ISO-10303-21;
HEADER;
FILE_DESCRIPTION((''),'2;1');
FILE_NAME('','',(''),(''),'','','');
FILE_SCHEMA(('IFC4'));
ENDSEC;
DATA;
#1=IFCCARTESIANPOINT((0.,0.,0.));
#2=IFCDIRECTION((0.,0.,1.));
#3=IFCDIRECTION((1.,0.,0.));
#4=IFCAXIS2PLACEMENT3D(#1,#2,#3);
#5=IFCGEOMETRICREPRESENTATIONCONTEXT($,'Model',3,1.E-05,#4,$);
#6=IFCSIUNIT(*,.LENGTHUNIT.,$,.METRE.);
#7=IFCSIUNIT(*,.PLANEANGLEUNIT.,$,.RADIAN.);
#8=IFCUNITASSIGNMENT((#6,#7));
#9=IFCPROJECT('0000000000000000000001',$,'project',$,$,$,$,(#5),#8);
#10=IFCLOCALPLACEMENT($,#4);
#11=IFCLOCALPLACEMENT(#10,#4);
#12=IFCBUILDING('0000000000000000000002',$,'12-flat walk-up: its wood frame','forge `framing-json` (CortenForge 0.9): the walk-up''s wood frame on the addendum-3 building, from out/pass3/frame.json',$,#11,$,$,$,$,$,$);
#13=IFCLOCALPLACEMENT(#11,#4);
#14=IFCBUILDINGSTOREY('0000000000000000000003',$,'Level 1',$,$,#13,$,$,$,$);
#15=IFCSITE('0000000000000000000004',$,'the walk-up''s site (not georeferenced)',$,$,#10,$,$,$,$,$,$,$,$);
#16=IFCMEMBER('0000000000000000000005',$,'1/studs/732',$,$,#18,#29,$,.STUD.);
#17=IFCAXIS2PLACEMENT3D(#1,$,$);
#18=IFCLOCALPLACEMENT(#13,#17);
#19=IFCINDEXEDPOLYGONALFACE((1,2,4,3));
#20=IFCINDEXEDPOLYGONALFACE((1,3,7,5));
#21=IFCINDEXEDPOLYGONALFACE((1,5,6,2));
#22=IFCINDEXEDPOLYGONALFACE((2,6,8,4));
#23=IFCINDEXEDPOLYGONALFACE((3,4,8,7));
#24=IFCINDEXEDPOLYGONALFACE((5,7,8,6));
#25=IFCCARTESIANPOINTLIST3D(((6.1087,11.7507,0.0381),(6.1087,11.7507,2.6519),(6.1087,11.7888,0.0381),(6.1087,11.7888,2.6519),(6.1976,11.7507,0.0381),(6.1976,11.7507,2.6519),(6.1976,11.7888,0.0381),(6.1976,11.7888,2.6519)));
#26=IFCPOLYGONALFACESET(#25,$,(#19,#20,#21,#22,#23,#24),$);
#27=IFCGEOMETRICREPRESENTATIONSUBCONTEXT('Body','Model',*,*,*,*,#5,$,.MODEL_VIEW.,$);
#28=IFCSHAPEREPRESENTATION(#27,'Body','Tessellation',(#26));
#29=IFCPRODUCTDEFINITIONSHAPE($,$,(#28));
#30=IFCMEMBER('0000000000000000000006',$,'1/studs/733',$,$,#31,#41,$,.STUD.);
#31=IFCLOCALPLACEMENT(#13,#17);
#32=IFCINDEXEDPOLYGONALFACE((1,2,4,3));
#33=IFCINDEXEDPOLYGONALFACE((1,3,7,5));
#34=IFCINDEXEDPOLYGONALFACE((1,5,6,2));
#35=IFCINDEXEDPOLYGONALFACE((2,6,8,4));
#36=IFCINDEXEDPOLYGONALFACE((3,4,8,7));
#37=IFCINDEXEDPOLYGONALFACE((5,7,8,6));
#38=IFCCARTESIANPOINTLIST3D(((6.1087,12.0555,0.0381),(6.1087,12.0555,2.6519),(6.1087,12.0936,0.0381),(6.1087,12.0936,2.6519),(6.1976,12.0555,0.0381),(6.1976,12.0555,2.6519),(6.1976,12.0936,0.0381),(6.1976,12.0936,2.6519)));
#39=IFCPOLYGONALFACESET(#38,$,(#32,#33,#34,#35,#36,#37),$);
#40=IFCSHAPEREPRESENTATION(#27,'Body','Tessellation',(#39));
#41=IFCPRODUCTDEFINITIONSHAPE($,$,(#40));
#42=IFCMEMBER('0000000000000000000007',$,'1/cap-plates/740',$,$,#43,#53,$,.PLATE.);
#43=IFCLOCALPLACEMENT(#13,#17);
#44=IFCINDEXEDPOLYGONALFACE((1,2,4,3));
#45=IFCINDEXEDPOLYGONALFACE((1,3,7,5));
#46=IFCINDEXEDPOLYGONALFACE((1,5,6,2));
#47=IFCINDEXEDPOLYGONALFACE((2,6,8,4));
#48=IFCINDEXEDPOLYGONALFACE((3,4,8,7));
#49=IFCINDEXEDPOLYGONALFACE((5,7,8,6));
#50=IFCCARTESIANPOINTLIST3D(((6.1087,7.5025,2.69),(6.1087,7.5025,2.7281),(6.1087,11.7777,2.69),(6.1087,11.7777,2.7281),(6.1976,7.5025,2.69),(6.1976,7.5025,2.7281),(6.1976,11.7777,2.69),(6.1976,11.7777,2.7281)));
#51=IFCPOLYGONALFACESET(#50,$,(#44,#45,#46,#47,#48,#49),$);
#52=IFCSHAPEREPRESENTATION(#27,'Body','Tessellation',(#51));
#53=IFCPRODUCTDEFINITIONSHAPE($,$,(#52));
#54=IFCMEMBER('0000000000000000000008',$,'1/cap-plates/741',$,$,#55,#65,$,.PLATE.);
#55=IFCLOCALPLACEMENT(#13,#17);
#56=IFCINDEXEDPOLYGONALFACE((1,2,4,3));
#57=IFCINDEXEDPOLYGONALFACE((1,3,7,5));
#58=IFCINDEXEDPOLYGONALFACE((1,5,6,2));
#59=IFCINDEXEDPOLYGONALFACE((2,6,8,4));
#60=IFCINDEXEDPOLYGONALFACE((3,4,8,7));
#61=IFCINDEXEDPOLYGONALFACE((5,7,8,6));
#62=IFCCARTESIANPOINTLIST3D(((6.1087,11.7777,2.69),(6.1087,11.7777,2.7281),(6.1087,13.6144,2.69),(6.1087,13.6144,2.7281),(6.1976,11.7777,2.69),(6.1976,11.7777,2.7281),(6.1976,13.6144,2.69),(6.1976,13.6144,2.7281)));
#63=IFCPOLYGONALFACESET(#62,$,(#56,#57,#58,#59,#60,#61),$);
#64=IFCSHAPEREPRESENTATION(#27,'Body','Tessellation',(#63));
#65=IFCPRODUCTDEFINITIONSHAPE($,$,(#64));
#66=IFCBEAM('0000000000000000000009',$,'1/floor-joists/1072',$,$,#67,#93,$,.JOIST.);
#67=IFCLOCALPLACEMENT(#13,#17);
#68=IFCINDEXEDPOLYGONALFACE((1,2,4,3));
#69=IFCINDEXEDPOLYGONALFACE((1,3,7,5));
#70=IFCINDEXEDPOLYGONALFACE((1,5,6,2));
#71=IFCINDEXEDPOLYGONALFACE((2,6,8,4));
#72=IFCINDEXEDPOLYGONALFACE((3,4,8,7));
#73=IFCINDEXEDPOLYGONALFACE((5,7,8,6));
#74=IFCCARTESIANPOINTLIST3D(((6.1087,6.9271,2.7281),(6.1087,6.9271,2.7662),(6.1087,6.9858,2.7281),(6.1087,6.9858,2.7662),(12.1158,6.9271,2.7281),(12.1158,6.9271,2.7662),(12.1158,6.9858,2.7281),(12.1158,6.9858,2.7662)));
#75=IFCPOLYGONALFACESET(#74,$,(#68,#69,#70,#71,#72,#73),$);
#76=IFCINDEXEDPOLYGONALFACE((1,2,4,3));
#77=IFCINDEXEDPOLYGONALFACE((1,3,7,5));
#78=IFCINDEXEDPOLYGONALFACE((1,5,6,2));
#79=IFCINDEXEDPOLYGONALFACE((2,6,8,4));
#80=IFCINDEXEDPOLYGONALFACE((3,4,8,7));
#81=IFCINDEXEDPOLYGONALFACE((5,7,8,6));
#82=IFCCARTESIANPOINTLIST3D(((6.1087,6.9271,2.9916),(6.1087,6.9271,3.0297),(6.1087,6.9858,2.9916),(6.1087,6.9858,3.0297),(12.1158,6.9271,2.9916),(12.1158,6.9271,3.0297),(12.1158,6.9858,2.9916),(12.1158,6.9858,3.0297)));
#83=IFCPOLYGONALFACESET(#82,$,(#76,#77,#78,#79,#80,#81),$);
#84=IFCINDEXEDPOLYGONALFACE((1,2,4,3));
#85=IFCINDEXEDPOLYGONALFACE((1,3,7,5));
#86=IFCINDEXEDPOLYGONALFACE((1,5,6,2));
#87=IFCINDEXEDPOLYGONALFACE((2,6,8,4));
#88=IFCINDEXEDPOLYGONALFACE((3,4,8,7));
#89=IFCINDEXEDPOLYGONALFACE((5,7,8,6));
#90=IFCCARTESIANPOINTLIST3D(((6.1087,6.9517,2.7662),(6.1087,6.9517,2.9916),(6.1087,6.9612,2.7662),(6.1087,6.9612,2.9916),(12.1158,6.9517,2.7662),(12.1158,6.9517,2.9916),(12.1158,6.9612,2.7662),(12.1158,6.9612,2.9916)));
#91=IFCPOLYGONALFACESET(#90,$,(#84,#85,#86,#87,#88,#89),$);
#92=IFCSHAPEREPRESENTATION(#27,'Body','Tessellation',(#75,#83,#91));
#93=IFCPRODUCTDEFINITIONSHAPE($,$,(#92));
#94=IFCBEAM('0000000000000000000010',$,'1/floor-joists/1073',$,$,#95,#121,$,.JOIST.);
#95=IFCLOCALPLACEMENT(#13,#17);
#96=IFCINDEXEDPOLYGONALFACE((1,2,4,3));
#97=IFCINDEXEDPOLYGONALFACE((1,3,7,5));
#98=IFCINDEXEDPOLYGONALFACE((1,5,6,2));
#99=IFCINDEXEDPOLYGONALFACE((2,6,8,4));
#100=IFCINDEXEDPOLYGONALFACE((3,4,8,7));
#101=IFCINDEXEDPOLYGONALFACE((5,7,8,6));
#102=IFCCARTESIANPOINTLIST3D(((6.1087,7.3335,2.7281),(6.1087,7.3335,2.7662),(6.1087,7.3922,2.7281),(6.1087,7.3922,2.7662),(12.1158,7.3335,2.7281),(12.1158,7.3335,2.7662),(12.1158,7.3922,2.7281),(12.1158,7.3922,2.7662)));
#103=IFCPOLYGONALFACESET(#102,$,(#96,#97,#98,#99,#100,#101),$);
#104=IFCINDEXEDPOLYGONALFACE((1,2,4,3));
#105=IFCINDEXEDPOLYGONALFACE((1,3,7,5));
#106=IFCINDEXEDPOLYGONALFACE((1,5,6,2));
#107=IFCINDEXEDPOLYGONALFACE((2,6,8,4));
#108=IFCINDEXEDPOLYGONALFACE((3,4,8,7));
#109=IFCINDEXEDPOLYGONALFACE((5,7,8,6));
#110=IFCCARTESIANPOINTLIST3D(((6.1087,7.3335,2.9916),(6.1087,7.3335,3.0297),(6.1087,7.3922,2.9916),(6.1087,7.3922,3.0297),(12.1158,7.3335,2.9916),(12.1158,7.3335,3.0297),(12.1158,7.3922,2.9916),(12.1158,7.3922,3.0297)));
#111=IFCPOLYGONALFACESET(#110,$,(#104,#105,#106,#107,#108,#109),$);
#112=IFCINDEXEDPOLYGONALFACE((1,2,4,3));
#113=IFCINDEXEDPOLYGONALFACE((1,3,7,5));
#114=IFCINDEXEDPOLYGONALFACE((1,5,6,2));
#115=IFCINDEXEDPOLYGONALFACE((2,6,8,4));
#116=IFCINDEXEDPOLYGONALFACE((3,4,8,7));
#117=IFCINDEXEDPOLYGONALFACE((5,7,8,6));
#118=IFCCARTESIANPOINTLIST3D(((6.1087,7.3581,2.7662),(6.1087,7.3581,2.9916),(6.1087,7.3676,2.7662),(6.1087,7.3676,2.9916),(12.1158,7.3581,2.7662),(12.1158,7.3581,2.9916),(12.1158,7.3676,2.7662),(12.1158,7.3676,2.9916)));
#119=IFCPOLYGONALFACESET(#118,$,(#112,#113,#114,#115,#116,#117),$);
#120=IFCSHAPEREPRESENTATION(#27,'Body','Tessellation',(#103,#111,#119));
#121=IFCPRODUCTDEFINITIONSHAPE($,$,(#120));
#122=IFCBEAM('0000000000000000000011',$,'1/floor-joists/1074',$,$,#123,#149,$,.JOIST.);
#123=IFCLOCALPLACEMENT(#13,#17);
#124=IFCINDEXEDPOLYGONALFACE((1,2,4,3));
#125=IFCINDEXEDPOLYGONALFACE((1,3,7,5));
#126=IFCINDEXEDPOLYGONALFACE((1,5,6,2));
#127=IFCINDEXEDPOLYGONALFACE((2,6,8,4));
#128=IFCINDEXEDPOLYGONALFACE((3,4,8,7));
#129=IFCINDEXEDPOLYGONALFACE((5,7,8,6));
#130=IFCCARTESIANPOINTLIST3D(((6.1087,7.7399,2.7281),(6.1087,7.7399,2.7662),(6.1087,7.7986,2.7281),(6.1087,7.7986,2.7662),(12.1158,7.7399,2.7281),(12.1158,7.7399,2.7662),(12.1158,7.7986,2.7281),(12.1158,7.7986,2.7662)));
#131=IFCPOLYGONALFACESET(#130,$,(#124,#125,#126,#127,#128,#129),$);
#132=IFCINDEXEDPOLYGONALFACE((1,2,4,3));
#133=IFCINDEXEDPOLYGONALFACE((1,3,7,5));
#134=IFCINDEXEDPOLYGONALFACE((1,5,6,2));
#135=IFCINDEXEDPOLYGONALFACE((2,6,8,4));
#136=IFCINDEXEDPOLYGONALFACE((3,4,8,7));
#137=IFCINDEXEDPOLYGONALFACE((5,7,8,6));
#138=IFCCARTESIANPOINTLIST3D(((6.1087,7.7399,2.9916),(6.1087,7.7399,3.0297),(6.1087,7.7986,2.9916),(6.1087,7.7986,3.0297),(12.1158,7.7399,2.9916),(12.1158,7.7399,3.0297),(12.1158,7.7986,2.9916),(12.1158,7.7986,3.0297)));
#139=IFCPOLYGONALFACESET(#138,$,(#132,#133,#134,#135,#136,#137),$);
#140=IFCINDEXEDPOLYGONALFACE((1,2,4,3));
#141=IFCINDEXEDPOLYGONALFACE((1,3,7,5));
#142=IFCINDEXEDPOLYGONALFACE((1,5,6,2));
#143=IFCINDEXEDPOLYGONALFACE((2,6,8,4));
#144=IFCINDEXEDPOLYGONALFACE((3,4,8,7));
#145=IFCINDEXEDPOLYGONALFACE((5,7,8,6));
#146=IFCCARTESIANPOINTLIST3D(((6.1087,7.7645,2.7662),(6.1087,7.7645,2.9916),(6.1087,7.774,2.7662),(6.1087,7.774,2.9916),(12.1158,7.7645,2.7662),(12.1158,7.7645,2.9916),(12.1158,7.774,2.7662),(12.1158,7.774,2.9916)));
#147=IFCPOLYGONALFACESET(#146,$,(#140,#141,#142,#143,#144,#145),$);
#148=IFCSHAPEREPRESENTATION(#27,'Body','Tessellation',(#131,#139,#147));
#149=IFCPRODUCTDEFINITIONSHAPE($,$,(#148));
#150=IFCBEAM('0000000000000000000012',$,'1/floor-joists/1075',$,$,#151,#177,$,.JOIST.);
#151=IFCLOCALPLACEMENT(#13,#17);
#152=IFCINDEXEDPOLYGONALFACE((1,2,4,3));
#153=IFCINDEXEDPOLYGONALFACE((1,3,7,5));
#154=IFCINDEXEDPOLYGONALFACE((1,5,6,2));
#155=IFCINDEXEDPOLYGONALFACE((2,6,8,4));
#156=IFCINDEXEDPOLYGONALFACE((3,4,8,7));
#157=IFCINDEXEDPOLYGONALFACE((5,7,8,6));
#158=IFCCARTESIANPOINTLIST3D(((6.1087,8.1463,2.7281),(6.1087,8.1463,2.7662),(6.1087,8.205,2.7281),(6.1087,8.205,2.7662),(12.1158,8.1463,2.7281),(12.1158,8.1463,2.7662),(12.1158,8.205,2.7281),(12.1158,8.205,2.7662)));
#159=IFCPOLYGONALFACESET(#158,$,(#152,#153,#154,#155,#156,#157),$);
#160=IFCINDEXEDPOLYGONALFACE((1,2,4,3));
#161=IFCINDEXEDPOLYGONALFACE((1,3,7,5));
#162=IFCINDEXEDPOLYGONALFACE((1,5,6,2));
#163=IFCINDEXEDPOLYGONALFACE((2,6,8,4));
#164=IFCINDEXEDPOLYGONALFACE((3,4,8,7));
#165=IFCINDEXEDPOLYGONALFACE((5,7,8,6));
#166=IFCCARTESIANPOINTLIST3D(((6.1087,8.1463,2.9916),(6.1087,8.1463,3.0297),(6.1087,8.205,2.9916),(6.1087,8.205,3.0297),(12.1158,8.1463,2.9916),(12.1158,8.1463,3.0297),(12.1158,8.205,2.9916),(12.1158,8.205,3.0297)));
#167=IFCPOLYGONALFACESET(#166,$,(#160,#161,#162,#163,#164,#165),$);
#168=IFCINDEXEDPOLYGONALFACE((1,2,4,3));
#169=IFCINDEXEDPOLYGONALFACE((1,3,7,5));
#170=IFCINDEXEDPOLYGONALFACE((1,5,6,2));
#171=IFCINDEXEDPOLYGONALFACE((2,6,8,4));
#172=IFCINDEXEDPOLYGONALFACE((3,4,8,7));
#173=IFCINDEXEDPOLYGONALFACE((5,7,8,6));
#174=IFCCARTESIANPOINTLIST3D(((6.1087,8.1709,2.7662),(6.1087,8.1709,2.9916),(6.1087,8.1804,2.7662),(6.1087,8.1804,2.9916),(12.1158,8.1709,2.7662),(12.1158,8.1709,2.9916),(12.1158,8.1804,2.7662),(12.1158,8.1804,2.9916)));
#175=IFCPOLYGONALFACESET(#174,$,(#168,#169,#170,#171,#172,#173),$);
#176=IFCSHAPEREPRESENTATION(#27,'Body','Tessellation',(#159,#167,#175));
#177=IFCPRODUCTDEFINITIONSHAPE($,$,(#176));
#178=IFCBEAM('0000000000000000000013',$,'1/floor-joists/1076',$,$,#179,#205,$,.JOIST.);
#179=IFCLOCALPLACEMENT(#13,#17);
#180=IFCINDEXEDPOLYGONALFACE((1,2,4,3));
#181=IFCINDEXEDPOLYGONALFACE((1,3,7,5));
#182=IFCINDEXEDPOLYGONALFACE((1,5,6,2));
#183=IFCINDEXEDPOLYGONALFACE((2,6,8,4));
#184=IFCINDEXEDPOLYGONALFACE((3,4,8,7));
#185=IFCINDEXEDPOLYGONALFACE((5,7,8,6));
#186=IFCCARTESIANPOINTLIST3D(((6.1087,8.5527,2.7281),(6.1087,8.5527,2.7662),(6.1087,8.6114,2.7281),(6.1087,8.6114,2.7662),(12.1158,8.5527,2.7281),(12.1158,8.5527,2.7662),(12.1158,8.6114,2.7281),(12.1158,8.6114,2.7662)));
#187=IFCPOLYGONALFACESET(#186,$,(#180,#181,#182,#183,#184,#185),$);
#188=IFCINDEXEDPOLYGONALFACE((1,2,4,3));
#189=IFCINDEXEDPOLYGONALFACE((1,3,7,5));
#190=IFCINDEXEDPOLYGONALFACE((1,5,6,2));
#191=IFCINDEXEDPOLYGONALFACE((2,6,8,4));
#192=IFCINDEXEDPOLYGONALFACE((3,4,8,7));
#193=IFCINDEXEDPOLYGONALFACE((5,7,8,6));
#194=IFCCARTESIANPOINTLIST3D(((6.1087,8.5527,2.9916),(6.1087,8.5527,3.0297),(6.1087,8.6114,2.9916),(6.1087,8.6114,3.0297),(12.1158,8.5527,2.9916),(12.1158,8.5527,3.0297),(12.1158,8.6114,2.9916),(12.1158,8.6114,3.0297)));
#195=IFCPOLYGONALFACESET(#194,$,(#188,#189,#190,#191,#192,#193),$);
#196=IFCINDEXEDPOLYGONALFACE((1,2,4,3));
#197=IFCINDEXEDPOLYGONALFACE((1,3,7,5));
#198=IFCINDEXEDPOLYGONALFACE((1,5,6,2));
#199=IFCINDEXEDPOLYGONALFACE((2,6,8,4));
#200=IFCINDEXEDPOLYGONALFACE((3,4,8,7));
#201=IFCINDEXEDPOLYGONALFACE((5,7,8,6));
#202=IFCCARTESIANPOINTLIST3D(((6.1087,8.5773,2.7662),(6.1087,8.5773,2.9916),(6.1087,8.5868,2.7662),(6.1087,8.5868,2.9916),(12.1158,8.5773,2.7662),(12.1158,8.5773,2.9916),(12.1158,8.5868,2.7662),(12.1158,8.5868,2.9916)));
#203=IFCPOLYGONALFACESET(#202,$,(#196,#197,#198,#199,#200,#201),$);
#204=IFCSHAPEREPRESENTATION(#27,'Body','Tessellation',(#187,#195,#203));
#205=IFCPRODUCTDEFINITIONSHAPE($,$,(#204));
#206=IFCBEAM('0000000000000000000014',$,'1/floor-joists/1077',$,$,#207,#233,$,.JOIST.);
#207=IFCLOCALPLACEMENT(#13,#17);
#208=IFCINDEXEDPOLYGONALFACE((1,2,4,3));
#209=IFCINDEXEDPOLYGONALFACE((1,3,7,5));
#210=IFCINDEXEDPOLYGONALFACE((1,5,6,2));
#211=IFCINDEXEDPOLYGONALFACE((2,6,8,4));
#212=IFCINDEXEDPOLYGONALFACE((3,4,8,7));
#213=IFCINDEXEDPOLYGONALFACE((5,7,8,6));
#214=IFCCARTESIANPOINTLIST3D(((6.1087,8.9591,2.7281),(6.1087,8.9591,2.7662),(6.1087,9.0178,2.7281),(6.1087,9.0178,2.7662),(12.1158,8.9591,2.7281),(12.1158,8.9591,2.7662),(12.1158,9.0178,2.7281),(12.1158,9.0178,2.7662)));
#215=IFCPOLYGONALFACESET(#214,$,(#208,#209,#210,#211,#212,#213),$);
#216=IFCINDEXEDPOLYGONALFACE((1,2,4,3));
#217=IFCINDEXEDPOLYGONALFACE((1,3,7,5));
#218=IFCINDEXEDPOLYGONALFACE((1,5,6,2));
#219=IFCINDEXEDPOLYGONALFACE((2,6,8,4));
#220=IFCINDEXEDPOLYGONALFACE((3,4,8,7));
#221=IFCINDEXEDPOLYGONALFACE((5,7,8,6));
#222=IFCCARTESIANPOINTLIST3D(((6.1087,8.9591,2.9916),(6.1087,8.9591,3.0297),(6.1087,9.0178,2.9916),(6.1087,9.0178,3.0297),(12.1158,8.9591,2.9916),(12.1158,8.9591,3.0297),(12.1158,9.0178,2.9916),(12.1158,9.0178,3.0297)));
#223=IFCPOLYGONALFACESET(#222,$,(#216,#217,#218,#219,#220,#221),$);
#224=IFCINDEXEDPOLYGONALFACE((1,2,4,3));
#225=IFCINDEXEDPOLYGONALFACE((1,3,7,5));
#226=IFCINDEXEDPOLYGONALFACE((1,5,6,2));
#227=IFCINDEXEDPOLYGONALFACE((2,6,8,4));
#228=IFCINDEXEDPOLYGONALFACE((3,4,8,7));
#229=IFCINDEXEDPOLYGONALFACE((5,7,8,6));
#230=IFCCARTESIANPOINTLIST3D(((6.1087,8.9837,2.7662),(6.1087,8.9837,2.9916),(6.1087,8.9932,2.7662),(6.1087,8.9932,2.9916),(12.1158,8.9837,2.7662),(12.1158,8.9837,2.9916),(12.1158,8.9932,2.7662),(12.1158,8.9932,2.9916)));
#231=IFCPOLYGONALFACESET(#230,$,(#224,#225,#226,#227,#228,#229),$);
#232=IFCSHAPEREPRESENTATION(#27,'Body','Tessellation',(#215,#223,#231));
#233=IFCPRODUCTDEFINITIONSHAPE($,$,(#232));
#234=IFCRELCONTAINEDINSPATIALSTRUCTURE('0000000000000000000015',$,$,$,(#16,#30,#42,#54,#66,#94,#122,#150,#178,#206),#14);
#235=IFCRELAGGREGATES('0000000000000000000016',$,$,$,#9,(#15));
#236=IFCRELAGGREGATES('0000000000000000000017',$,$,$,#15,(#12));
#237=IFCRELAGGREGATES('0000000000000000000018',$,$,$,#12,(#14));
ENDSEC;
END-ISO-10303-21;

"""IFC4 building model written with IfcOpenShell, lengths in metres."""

from ifc_helpers import new_model, si_unit, frame, frame_2d, origin, origin_with_axes, place, context, subcontext, project, spatial, rectangle, extrude, element, save


model = new_model("IFC4")

# Units and contexts
model_context = context("Model", 3, precision=1e-05, world=origin_with_axes())
body_context = subcontext(model_context, "Body", "Model", "MODEL_VIEW")
ifc_project = project(units=[si_unit("LENGTHUNIT", "METRE"), si_unit("PLANEANGLEUNIT", "RADIAN")], contexts=[model_context])

# Site, building, storey
site_placement = place(None, origin_with_axes())
site = spatial("IfcSite", under=ifc_project, at=site_placement, Name="the walk-up's site (not georeferenced)")
building_placement = place(site_placement, origin_with_axes())
building = spatial("IfcBuilding", under=site, at=building_placement, Name="12-flat walk-up: its wood frame", Description="forge `framing-json` (CortenForge 0.9): the walk-up's wood frame on the addendum-3 building, from out/pass3/frame.json")
storey_placement = place(building_placement, origin_with_axes())
storey = spatial("IfcBuildingStorey", under=building, at=storey_placement, Name="Level 1")

# Members
for number, where, z_axis, x_axis, name in (
    (1, (6.1087, 11.7507, 0.0381), (0.0, 0.0, 1.0), (1.0, 0.0, 0.0), "1/studs/732"),
    (2, (6.1087, 12.0555, 0.0381), (0.0, 0.0, 1.0), (1.0, 0.0, 0.0), "1/studs/733"),
):
    element("IfcMember", number, at=place(storey_placement, frame(where, z_axis=z_axis, x_axis=x_axis)), inside=storey, Name=name, PredefinedType="STUD", context=body_context, shape_type="SweptSolid", body=[
        extrude(rectangle(XDim=0.0889, YDim=0.0381, at=frame_2d((0.0445, 0.0191))), origin(), (0.0, 0.0, 1.0), 2.6138),
    ])
member_1_placement = place(storey_placement, frame((6.1087, 7.5025, 2.69), z_axis=(0.0, 0.0, 1.0), x_axis=(1.0, 0.0, 0.0)))
element("IfcMember", 3, at=member_1_placement, inside=storey, Name="1/cap-plates/740", PredefinedType="PLATE", context=body_context, shape_type="SweptSolid", body=[
    extrude(rectangle(XDim=0.0889, YDim=4.2751, at=frame_2d((0.0445, 2.1376))), origin(), (0.0, 0.0, 1.0), 0.0381),
])
member_2_placement = place(storey_placement, frame((6.1087, 11.7777, 2.69), z_axis=(0.0, 0.0, 1.0), x_axis=(1.0, 0.0, 0.0)))
element("IfcMember", 4, at=member_2_placement, inside=storey, Name="1/cap-plates/741", PredefinedType="PLATE", context=body_context, shape_type="SweptSolid", body=[
    extrude(rectangle(XDim=0.0889, YDim=1.8367, at=frame_2d((0.0445, 0.9184))), origin(), (0.0, 0.0, 1.0), 0.0381),
])

# Beams
beam_1_placement = place(storey_placement, frame((6.1087, 6.9271, 2.7281), z_axis=(0.0, 0.0, 1.0), x_axis=(1.0, 0.0, 0.0)))
element("IfcBeam", 5, at=beam_1_placement, inside=storey, Name="1/floor-joists/1072", PredefinedType="JOIST", context=body_context, shape_type="SweptSolid", body=[
    extrude(rectangle(XDim=6.0071, YDim=0.0587, at=frame_2d((3.0036, 0.0294))), origin(), (0.0, 0.0, 1.0), 0.0381),
    extrude(rectangle(XDim=6.0071, YDim=0.0587, at=frame_2d((3.0036, 0.0294))), frame((0.0, 0.0, 0.2635)), (0.0, 0.0, 1.0), 0.0381),
    extrude(rectangle(XDim=6.0071, YDim=0.0095, at=frame_2d((3.0036, 0.0048))), frame((0.0, 0.0246, 0.0381)), (0.0, 0.0, 1.0), 0.2254),
])
for number, where, z_axis, x_axis, name in (
    (6, (6.1087, 7.3335, 2.7281), (0.0, 0.0, 1.0), (1.0, 0.0, 0.0), "1/floor-joists/1073"),
    (7, (6.1087, 7.7399, 2.7281), (0.0, 0.0, 1.0), (1.0, 0.0, 0.0), "1/floor-joists/1074"),
    (8, (6.1087, 8.1463, 2.7281), (0.0, 0.0, 1.0), (1.0, 0.0, 0.0), "1/floor-joists/1075"),
):
    element("IfcBeam", number, at=place(storey_placement, frame(where, z_axis=z_axis, x_axis=x_axis)), inside=storey, Name=name, PredefinedType="JOIST", context=body_context, shape_type="SweptSolid", body=[
        extrude(rectangle(XDim=6.0071, YDim=0.0587, at=frame_2d((3.0036, 0.0294))), origin(), (0.0, 0.0, 1.0), 0.0381),
        extrude(rectangle(XDim=6.0071, YDim=0.0587, at=frame_2d((3.0036, 0.0294))), frame((0.0, 0.0, 0.2635)), (0.0, 0.0, 1.0), 0.0381),
        extrude(rectangle(XDim=6.0071, YDim=0.0095, at=frame_2d((3.0036, 0.0048))), frame((0.0, 0.0246, 0.0381)), (0.0, 0.0, 1.0), 0.2254),
    ])
beam_2_placement = place(storey_placement, frame((6.1087, 8.5527, 2.7281), z_axis=(0.0, 0.0, 1.0), x_axis=(1.0, 0.0, 0.0)))
element("IfcBeam", 9, at=beam_2_placement, inside=storey, Name="1/floor-joists/1076", PredefinedType="JOIST", context=body_context, shape_type="SweptSolid", body=[
    extrude(rectangle(XDim=6.0071, YDim=0.0587, at=frame_2d((3.0036, 0.0294))), origin(), (0.0, 0.0, 1.0), 0.0381),
    extrude(rectangle(XDim=6.0071, YDim=0.0587, at=frame_2d((3.0036, 0.0294))), frame((0.0, 0.0, 0.2635)), (0.0, 0.0, 1.0), 0.0381),
    extrude(rectangle(XDim=6.0071, YDim=0.0095, at=frame_2d((3.0036, 0.0048))), frame((0.0, 0.0246, 0.0381)), (0.0, 0.0, 1.0), 0.2254),
])
for number, where, z_axis, x_axis, name in (
    (10, (6.1087, 8.9591, 2.7281), (0.0, 0.0, 1.0), (1.0, 0.0, 0.0), "1/floor-joists/1077"),
):
    element("IfcBeam", number, at=place(storey_placement, frame(where, z_axis=z_axis, x_axis=x_axis)), inside=storey, Name=name, PredefinedType="JOIST", context=body_context, shape_type="SweptSolid", body=[
        extrude(rectangle(XDim=6.0071, YDim=0.0587, at=frame_2d((3.0036, 0.0294))), origin(), (0.0, 0.0, 1.0), 0.0381),
        extrude(rectangle(XDim=6.0071, YDim=0.0587, at=frame_2d((3.0036, 0.0294))), frame((0.0, 0.0, 0.2635)), (0.0, 0.0, 1.0), 0.0381),
        extrude(rectangle(XDim=6.0071, YDim=0.0095, at=frame_2d((3.0036, 0.0048))), frame((0.0, 0.0246, 0.0381)), (0.0, 0.0, 1.0), 0.2254),
    ])

save(model, "model.ifc")
